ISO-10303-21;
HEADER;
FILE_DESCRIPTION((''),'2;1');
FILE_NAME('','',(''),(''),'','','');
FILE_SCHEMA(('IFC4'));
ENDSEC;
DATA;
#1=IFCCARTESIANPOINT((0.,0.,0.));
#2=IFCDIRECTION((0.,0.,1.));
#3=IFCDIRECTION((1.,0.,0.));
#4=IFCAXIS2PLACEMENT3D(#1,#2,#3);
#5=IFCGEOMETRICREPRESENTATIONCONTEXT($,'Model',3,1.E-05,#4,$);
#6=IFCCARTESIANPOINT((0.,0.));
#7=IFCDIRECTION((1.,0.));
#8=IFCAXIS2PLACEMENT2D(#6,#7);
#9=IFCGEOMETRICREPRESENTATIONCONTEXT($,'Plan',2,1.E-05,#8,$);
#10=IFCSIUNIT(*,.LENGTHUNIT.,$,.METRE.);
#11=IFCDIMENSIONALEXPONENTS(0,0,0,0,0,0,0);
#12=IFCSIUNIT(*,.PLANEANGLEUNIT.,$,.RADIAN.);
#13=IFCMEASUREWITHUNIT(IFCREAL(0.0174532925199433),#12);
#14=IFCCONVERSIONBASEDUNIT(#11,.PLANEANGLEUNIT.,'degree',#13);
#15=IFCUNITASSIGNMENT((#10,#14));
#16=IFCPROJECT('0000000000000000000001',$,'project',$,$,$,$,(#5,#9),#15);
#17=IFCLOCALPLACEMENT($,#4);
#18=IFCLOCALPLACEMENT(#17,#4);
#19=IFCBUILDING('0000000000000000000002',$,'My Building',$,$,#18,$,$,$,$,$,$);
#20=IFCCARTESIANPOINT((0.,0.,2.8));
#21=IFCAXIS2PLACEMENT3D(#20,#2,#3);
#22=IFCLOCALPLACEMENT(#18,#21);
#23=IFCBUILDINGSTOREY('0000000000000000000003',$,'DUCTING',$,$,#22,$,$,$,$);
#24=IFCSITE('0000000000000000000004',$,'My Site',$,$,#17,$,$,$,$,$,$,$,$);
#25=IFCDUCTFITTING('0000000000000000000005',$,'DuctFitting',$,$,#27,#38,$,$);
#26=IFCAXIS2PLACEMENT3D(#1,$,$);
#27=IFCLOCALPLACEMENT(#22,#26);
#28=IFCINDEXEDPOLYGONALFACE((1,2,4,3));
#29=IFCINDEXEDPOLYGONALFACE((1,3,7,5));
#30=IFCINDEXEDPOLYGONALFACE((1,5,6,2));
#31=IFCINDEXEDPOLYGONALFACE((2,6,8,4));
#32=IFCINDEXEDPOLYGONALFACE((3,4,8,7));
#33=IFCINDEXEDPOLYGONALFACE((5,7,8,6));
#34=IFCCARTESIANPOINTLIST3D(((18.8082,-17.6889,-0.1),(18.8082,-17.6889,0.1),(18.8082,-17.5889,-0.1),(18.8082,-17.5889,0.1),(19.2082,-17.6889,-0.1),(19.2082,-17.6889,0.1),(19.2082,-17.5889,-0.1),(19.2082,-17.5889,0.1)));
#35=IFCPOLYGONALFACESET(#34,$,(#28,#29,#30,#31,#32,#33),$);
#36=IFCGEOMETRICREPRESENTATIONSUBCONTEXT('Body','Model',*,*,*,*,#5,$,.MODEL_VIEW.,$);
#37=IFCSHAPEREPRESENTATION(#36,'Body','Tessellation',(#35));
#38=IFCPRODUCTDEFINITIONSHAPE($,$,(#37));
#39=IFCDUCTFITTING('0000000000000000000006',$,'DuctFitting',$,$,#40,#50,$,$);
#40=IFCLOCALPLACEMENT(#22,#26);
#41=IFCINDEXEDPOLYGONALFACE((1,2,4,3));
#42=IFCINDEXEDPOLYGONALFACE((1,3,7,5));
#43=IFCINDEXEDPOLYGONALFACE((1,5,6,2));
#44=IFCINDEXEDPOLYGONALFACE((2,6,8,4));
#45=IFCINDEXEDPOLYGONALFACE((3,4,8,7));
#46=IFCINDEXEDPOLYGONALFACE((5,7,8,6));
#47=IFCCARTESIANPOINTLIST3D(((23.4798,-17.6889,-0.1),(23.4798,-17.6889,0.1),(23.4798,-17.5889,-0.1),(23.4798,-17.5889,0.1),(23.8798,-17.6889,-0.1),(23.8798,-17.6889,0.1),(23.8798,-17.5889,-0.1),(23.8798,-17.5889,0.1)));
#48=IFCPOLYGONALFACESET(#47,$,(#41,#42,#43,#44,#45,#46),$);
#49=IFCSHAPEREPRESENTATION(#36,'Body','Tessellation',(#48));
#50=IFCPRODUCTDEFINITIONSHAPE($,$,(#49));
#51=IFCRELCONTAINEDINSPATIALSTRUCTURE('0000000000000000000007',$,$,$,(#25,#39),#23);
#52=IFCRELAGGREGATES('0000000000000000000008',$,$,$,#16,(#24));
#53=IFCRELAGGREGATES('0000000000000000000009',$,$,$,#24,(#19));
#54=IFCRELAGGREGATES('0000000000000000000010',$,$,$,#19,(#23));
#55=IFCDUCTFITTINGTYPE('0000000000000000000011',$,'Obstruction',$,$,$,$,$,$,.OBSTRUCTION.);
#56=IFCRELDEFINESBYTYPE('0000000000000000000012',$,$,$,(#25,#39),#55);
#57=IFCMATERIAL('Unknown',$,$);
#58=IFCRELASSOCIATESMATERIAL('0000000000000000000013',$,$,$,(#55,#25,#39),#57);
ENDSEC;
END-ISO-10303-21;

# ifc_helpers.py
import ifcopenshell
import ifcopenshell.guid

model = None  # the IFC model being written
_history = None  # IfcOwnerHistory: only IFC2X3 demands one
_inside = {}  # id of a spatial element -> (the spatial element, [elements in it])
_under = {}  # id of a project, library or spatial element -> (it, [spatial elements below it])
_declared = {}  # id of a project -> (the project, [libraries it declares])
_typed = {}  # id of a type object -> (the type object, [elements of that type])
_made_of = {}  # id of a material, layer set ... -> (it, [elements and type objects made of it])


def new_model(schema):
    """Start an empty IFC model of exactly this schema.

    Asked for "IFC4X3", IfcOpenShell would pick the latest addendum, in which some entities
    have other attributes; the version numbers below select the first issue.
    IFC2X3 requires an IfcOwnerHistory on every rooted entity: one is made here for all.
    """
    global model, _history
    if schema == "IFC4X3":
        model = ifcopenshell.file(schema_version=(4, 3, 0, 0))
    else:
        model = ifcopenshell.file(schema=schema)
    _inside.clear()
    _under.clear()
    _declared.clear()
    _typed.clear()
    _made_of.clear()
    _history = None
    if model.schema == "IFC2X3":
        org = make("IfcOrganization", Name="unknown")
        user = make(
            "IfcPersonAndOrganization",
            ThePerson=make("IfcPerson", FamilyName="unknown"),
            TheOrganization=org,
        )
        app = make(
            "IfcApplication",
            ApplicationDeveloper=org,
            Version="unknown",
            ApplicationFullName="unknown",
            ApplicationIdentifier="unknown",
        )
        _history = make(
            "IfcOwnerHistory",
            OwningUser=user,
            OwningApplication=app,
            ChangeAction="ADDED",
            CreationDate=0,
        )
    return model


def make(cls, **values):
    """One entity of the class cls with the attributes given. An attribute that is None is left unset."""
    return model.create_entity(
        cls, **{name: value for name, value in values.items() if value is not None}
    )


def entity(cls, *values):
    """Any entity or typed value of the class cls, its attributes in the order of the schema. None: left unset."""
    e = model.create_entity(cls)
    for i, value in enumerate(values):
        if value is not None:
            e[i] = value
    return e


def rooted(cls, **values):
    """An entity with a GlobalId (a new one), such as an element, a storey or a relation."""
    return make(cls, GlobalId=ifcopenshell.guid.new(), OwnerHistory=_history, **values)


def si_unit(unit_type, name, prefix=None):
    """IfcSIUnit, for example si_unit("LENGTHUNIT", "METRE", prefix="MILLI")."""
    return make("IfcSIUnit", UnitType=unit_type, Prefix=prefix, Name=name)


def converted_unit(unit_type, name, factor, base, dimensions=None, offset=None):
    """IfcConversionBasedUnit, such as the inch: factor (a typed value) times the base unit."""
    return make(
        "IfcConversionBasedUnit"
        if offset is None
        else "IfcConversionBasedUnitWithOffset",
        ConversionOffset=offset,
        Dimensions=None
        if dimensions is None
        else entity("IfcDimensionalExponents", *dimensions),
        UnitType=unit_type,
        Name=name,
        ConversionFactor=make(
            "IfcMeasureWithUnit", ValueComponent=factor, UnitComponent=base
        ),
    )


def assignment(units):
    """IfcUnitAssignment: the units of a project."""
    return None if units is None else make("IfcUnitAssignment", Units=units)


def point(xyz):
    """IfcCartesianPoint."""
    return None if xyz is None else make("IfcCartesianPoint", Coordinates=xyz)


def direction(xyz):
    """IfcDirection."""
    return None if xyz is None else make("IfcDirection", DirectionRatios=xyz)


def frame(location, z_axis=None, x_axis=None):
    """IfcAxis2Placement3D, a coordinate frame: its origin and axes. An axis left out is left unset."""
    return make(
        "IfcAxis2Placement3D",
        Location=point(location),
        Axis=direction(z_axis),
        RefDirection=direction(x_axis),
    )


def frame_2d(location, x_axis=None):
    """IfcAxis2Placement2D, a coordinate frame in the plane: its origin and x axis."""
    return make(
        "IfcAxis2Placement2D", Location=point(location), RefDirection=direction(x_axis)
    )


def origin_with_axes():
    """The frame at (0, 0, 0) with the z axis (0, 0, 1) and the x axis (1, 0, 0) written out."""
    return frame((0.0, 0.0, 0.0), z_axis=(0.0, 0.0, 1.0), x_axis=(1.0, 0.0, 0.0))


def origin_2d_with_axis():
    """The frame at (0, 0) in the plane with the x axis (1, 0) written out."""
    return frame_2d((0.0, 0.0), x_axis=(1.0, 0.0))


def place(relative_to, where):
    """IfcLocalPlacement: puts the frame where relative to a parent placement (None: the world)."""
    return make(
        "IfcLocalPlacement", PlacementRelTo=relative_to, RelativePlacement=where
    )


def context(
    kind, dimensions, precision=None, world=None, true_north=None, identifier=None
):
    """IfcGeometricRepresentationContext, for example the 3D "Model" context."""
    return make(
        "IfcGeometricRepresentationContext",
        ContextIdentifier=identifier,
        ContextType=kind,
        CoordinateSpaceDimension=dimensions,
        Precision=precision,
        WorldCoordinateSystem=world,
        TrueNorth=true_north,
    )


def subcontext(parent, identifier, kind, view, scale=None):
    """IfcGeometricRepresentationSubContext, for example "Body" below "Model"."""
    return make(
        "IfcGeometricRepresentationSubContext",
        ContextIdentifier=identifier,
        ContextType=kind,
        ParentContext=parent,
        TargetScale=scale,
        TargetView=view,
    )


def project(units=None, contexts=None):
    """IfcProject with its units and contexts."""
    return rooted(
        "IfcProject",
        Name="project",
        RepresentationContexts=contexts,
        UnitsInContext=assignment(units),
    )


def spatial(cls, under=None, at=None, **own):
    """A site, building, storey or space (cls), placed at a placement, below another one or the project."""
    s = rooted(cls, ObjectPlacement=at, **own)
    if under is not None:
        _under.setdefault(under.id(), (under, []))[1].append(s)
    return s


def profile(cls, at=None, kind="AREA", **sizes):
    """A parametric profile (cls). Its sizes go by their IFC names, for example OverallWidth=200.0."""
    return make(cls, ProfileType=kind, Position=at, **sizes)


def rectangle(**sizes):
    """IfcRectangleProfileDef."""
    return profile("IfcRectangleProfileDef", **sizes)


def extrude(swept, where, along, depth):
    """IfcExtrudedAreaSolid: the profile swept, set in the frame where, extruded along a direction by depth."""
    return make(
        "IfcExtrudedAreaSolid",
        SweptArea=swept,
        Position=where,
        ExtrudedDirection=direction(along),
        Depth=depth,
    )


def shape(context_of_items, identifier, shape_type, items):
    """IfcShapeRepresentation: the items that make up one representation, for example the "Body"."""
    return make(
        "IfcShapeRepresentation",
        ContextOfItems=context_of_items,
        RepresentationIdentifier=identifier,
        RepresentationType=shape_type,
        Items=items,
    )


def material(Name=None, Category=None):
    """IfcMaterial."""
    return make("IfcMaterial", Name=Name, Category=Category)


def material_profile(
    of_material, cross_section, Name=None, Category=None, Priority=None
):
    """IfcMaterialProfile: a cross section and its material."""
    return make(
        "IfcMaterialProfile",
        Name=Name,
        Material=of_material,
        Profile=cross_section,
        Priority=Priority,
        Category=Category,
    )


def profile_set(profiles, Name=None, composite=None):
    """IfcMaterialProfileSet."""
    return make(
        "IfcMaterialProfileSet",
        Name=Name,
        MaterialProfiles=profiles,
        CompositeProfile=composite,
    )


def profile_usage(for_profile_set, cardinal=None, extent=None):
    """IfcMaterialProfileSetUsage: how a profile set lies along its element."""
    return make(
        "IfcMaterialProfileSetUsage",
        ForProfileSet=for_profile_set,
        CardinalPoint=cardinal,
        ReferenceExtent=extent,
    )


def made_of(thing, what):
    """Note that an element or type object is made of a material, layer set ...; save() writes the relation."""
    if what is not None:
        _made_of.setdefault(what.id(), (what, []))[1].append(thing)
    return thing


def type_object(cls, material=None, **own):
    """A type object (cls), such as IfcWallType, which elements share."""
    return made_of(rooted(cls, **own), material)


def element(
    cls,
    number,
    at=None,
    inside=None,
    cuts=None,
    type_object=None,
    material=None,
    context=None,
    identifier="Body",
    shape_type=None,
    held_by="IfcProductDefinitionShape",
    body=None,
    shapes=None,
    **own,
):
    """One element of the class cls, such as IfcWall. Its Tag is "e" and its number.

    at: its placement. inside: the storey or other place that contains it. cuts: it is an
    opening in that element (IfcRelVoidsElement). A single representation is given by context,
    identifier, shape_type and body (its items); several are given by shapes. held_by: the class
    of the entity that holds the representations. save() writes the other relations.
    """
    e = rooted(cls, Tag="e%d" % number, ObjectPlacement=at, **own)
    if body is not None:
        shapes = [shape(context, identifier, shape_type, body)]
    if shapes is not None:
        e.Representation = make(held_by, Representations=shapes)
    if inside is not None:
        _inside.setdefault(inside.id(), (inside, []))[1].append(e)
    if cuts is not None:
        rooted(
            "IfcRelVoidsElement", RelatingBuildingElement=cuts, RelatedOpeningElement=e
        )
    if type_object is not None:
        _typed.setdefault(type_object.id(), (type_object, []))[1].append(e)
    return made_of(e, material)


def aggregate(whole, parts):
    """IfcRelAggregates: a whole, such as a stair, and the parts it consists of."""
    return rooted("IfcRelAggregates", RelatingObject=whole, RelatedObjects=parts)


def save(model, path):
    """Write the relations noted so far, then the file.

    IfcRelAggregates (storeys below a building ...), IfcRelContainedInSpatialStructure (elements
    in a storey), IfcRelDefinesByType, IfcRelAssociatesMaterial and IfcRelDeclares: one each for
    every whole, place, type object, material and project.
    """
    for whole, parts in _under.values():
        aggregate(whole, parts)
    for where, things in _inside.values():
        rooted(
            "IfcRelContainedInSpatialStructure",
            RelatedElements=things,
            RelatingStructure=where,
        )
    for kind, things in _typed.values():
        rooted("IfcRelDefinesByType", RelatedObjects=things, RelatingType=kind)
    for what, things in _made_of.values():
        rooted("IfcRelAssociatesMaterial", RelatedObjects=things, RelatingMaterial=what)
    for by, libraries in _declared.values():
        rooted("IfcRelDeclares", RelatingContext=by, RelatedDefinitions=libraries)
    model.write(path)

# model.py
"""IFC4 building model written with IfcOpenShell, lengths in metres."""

from ifc_helpers import new_model, entity, si_unit, converted_unit, frame, origin_with_axes, origin_2d_with_axis, place, context, subcontext, project, spatial, rectangle, extrude, material, material_profile, profile_set, profile_usage, type_object, element, save


model = new_model("IFC4")

# Units and contexts
model_context = context("Model", 3, precision=1e-05, world=origin_with_axes())
plan_context = context("Plan", 2, precision=1e-05, world=origin_2d_with_axis())
body_context = subcontext(model_context, "Body", "Model", "MODEL_VIEW")
ifc_project = project(units=[si_unit("LENGTHUNIT", "METRE"), converted_unit("PLANEANGLEUNIT", "degree", entity("IfcReal", 0.0174532925199433), si_unit("PLANEANGLEUNIT", "RADIAN"), dimensions=[0, 0, 0, 0, 0, 0, 0])], contexts=[model_context, plan_context])

# Site, building, storey
site_placement = place(None, origin_with_axes())
site = spatial("IfcSite", under=ifc_project, at=site_placement, Name="My Site")
building_placement = place(site_placement, origin_with_axes())
building = spatial("IfcBuilding", under=site, at=building_placement, Name="My Building")
storey_placement = place(building_placement, frame((0.0, 0.0, 2.8), z_axis=(0.0, 0.0, 1.0), x_axis=(1.0, 0.0, 0.0)))
storey = spatial("IfcBuildingStorey", under=building, at=storey_placement, Name="DUCTING")

# Shared definitions
ifc_material = material(Name="Unknown")

# Duct fittings
ifc_material_profile_1 = material_profile(ifc_material, rectangle(XDim=0.4, YDim=0.2))
ifc_profile_set_1 = profile_set([ifc_material_profile_1])
duct_fitting_type_1 = type_object("IfcDuctFittingType", Name="Obstruction", PredefinedType="OBSTRUCTION", material=ifc_profile_set_1)
ifc_profile_usage_1 = profile_usage(ifc_profile_set_1, cardinal=5)
duct_fitting_1_placement = place(storey_placement, frame((19.0082, -17.6889, 0.0), z_axis=(0.0, 1.0, 0.0), x_axis=(-1.0, 0.0, 0.0)))
element("IfcDuctFitting", 1, at=duct_fitting_1_placement, inside=storey, type_object=duct_fitting_type_1, material=ifc_profile_usage_1, Name="DuctFitting", context=body_context, shape_type="SweptSolid", body=[
    extrude(rectangle(XDim=0.4, YDim=0.2), origin_with_axes(), (0.0, 0.0, 1.0), 0.1),
])
ifc_profile_usage_2 = profile_usage(ifc_profile_set_1, cardinal=5)
duct_fitting_2_placement = place(storey_placement, frame((23.6798, -17.6889, 0.0), z_axis=(0.0, 1.0, 0.0), x_axis=(-1.0, 0.0, 0.0)))
element("IfcDuctFitting", 2, at=duct_fitting_2_placement, inside=storey, type_object=duct_fitting_type_1, material=ifc_profile_usage_2, Name="DuctFitting", context=body_context, shape_type="SweptSolid", body=[
    extrude(rectangle(XDim=0.4, YDim=0.2), origin_with_axes(), (0.0, 0.0, 1.0), 0.1),
])

save(model, "model.ifc")
